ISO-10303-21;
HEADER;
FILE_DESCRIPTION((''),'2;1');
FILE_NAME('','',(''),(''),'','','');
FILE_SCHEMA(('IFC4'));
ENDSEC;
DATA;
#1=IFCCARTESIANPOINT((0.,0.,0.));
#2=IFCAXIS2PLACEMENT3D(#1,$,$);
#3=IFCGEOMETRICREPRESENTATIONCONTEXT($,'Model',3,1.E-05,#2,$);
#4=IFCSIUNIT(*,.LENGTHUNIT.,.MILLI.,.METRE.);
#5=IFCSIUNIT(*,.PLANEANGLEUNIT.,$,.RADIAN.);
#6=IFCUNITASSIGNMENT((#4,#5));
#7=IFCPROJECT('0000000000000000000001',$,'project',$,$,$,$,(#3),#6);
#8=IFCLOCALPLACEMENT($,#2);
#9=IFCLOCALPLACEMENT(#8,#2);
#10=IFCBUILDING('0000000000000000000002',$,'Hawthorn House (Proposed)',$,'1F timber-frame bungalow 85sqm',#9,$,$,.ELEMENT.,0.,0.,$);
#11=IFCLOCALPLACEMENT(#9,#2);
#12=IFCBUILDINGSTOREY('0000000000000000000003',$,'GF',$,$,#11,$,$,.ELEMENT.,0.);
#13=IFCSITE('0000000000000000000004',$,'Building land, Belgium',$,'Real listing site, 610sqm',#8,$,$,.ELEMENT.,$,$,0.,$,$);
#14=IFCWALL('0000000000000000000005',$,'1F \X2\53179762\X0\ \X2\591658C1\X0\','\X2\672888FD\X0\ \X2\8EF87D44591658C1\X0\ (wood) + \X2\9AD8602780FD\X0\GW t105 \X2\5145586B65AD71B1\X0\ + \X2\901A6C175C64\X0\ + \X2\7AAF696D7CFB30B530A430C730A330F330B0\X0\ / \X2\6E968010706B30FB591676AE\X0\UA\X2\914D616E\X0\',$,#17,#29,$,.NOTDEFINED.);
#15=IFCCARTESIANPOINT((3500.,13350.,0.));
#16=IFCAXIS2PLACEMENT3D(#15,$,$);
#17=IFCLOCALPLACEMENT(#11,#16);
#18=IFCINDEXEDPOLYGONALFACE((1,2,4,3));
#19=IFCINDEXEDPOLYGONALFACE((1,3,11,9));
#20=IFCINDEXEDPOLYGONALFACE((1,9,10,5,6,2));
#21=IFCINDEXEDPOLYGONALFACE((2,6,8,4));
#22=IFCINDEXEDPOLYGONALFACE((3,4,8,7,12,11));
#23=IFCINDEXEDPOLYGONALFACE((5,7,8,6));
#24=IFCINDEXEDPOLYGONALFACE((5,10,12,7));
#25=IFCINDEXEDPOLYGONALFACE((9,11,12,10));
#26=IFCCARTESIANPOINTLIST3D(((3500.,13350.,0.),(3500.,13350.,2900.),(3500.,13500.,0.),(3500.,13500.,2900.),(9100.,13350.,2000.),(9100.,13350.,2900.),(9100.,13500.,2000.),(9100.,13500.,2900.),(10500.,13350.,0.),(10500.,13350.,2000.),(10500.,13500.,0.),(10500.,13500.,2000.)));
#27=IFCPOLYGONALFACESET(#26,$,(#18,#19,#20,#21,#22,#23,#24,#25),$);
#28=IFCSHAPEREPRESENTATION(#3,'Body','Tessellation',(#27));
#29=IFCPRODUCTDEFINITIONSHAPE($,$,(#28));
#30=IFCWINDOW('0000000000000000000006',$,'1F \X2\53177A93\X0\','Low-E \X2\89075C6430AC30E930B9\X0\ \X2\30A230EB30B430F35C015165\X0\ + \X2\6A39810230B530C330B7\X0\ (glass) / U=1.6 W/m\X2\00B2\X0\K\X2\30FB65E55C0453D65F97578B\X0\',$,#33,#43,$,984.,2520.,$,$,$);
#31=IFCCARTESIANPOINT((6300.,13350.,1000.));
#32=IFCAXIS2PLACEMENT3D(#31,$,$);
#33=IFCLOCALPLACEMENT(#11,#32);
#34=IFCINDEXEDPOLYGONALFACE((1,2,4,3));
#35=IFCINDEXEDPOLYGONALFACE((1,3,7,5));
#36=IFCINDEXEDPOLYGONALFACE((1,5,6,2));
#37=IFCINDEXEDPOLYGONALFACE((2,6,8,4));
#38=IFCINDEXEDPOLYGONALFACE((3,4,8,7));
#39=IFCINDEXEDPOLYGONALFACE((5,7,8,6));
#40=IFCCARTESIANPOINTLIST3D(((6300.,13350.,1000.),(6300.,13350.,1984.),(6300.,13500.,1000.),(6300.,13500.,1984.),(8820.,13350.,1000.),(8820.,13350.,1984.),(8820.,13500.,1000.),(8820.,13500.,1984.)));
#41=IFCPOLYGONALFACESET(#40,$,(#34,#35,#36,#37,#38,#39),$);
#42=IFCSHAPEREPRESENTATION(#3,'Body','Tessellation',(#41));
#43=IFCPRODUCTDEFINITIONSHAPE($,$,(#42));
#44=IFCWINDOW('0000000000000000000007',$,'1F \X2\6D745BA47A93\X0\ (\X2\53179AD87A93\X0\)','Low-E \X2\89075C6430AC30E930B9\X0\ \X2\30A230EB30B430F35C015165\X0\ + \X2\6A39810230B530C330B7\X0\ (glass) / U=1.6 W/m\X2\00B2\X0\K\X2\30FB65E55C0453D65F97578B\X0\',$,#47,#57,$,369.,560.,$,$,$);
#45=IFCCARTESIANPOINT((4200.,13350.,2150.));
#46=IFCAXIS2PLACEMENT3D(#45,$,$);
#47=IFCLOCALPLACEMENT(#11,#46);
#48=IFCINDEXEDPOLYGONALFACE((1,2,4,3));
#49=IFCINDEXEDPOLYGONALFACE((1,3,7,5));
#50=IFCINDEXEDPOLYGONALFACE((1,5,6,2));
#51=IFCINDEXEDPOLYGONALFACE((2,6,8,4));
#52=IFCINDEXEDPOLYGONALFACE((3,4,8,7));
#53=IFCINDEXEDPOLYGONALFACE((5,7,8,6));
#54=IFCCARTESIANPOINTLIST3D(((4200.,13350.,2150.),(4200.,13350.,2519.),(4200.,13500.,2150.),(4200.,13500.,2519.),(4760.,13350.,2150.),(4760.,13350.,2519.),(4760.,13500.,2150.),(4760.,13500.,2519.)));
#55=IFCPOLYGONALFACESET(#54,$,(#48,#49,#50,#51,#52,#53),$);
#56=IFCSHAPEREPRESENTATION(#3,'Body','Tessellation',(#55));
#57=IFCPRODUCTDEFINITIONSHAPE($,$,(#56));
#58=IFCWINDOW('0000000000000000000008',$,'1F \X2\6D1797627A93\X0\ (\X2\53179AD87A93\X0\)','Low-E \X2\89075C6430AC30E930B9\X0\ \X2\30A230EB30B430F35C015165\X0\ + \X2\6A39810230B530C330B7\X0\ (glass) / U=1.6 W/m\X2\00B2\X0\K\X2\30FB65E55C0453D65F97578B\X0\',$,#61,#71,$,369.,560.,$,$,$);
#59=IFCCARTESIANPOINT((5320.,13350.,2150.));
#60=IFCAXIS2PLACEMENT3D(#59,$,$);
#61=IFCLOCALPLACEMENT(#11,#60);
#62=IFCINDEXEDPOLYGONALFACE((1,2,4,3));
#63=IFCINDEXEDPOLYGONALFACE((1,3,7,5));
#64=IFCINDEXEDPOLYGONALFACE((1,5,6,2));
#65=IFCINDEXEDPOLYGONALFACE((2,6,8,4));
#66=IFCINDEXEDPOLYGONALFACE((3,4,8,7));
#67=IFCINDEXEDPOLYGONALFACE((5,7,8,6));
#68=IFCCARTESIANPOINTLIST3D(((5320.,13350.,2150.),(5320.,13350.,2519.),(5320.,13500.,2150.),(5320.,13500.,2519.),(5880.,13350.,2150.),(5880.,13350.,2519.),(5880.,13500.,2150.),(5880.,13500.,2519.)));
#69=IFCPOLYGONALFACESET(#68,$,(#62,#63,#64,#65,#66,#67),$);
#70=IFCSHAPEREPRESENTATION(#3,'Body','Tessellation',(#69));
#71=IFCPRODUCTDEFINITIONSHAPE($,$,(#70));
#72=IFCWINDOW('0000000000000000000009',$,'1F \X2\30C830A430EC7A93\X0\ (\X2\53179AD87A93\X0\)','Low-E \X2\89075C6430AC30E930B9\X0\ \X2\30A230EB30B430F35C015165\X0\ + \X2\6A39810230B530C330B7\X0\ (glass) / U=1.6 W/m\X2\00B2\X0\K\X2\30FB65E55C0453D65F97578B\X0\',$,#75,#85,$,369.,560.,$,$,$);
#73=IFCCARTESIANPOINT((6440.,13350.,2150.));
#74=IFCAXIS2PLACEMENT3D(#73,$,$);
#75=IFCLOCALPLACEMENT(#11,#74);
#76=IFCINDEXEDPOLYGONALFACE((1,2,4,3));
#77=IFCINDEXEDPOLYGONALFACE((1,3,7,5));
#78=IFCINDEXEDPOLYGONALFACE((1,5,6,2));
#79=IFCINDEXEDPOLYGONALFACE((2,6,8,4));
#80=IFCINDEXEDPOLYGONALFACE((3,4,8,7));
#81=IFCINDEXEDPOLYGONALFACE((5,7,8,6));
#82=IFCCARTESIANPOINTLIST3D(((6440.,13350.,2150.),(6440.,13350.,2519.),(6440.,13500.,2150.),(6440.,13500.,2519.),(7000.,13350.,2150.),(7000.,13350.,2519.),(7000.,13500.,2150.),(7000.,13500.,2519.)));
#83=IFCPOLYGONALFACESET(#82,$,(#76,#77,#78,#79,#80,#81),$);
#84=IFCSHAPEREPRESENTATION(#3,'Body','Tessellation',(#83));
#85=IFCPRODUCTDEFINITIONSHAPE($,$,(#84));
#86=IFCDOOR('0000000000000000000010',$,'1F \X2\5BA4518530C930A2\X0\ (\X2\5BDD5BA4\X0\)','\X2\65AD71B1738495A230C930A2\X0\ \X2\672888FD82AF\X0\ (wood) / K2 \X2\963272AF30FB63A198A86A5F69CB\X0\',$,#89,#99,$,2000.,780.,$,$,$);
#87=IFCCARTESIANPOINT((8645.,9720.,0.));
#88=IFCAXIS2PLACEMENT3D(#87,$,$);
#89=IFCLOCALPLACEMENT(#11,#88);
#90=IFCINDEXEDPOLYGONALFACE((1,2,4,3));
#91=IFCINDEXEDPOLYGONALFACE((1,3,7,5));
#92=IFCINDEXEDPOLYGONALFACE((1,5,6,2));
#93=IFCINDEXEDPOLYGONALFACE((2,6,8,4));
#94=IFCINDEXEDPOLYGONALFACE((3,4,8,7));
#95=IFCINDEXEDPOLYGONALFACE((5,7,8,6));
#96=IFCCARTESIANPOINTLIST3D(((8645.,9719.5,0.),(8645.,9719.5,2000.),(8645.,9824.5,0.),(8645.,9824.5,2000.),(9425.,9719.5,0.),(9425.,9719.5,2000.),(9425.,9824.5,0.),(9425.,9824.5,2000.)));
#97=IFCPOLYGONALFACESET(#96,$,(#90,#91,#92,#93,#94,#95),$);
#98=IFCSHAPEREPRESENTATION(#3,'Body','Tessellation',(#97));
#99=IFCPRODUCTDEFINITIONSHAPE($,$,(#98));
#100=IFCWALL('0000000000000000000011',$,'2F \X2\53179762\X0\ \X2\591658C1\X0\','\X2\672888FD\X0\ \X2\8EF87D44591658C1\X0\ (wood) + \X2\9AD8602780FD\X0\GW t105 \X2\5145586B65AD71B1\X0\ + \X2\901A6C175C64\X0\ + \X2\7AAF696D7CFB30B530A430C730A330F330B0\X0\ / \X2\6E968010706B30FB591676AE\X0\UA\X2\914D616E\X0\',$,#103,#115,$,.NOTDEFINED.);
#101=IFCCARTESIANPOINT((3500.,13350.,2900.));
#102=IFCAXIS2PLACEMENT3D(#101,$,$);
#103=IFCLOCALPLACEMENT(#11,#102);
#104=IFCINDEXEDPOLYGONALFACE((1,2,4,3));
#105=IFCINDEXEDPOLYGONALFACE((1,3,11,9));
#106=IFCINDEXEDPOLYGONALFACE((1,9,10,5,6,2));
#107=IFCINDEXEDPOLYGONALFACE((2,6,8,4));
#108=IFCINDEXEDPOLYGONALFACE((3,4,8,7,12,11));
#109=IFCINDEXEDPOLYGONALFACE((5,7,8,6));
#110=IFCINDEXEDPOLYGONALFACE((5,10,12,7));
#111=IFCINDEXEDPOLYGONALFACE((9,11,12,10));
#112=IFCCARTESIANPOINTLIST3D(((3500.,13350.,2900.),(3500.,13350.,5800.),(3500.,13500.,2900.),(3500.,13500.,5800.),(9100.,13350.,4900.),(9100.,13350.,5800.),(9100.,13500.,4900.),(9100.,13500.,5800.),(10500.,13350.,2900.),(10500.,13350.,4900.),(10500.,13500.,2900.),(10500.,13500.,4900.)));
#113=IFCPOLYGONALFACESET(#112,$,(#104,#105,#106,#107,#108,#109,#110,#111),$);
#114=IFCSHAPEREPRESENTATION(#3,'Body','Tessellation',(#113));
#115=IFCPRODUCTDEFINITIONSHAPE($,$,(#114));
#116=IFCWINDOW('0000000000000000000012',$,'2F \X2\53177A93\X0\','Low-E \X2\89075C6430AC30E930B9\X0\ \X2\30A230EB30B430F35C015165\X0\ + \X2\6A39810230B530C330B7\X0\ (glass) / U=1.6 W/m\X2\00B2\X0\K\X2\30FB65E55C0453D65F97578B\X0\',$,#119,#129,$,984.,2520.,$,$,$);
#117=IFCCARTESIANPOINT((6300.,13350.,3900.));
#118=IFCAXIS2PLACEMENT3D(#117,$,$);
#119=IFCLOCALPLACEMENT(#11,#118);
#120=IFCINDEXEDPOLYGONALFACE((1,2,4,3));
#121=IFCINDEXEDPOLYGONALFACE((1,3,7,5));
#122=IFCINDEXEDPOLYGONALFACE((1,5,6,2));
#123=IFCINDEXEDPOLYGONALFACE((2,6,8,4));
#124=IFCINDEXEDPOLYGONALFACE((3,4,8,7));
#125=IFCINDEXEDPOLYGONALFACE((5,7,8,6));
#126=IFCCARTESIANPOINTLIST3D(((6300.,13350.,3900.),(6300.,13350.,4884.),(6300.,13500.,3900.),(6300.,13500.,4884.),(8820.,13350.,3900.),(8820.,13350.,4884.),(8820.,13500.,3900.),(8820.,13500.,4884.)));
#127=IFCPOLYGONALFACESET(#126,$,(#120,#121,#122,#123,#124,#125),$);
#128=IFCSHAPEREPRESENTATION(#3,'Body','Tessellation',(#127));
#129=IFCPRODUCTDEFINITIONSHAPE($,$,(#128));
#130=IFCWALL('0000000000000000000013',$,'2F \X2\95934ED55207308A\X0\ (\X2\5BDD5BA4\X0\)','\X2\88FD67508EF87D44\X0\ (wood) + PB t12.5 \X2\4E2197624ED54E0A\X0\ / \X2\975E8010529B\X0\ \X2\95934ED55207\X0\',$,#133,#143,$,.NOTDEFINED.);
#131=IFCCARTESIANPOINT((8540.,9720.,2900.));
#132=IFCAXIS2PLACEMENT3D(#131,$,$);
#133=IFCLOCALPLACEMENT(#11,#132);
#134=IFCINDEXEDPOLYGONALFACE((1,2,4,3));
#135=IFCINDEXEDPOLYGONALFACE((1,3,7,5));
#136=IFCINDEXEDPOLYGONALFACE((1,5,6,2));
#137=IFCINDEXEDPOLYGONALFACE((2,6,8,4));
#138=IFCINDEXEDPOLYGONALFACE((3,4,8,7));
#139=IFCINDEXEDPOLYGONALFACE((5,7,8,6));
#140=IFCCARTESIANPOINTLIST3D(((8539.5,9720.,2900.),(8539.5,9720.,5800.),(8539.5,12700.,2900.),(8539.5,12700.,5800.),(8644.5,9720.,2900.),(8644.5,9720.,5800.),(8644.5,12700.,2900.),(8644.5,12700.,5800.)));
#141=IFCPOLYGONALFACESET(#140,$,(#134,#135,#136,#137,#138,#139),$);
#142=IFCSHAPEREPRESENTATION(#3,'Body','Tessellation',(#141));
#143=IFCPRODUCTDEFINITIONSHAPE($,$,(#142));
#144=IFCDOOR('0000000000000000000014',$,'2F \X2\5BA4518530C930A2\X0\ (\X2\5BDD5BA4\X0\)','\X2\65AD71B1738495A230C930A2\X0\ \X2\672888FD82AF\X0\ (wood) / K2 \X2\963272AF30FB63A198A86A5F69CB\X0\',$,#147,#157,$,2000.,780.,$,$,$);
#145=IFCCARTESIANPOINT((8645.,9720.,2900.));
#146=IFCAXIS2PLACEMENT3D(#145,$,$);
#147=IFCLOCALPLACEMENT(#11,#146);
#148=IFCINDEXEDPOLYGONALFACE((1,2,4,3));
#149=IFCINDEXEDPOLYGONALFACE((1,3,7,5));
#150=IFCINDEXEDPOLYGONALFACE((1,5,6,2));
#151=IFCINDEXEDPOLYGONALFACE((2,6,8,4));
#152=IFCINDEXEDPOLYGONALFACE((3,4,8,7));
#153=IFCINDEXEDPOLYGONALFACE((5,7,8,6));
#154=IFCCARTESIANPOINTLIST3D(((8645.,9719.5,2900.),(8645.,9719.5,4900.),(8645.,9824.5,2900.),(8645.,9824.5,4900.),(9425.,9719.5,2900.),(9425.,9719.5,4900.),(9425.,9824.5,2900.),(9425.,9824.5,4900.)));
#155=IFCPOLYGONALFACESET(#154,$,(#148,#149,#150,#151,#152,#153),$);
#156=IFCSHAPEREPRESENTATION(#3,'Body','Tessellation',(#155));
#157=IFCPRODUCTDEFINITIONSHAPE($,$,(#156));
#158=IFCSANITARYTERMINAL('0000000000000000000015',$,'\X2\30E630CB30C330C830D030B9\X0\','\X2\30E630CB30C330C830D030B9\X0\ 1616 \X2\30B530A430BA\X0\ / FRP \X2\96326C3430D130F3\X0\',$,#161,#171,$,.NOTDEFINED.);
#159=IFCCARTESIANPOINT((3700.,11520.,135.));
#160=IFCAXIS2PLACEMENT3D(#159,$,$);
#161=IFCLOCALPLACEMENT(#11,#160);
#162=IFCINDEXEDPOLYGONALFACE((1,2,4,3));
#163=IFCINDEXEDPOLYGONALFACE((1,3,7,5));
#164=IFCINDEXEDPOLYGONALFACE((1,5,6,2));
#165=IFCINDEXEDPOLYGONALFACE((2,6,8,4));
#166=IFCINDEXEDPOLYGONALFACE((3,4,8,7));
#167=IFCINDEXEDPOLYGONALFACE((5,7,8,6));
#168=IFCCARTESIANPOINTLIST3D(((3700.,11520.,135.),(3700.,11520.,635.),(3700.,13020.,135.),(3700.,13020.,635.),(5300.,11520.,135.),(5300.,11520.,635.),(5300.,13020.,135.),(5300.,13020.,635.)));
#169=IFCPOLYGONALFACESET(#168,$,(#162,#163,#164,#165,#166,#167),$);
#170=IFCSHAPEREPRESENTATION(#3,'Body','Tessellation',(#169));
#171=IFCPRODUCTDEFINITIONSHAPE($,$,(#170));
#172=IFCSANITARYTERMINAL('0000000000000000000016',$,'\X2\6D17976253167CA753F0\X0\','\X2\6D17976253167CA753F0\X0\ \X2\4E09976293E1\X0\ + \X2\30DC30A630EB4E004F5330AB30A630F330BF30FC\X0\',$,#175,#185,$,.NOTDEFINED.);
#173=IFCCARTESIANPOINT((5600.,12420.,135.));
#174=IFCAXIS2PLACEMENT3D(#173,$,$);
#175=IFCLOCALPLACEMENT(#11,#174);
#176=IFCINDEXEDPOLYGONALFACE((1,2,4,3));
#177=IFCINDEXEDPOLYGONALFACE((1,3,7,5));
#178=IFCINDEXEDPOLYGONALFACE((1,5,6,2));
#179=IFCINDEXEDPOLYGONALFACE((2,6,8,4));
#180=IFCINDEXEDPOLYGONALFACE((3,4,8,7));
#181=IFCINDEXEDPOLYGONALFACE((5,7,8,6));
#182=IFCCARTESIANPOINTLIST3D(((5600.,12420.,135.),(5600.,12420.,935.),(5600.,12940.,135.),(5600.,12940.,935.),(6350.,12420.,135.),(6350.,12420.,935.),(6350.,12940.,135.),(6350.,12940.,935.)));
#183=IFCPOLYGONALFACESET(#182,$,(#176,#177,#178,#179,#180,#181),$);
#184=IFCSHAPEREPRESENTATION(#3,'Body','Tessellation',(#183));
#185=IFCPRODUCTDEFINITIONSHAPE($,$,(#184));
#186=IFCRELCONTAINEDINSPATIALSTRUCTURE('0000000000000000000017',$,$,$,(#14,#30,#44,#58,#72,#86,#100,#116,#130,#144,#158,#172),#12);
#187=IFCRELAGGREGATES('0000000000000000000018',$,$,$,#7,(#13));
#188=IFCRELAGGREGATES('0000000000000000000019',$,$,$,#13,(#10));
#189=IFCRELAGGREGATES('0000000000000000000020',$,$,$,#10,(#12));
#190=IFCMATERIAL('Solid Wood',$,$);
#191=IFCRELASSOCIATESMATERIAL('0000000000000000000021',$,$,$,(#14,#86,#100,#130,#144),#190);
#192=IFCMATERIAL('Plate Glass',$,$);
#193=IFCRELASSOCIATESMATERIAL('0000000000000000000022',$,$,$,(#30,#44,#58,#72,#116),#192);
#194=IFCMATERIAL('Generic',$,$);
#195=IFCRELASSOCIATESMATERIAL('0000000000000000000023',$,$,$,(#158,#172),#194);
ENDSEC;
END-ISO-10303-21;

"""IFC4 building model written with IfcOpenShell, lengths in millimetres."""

from ifc_helpers import new_model, si_unit, frame, frame_2d, origin, place, context, project, spatial, rectangle, extrude, material, element, fill, save


model = new_model("IFC4")

# Units and contexts
model_context = context("Model", 3, precision=1e-05, world=origin())
ifc_project = project(units=[si_unit("LENGTHUNIT", "METRE", prefix="MILLI"), si_unit("PLANEANGLEUNIT", "RADIAN")], contexts=[model_context])

# Site, building, storey
site_placement = place(None, origin())
site = spatial("IfcSite", under=ifc_project, at=site_placement, Name="Building land, Belgium", ObjectType="Real listing site, 610sqm", CompositionType="ELEMENT", RefElevation=0.0)
building_placement = place(site_placement, origin())
building = spatial("IfcBuilding", under=site, at=building_placement, Name="Hawthorn House (Proposed)", ObjectType="1F timber-frame bungalow 85sqm", CompositionType="ELEMENT", ElevationOfRefHeight=0.0, ElevationOfTerrain=0.0)
storey_placement = place(building_placement, origin())
storey = spatial("IfcBuildingStorey", under=building, at=storey_placement, Name="GF", CompositionType="ELEMENT", Elevation=0.0)

# Wall, openings, windows
ifc_material_1 = material(Name="Solid Wood")
wall_1_placement = place(storey_placement, frame((3500.0, 13350.0, 0.0)))
wall_1 = element("IfcWall", 1, at=wall_1_placement, inside=storey, material=ifc_material_1, Name="1F 北面 外壁", Description="木製 軸組外壁 (wood) + 高性能GW t105 充填断熱 + 通気層 + 窯業系サイディング / 準耐火・外皮UA配慮", PredefinedType="NOTDEFINED", context=model_context, shape_type="SweptSolid", body=[
    extrude(rectangle(XDim=7000.0, YDim=150.0, at=frame_2d((3500.0, 75.0))), frame((3500.0, 13350.0, 0.0)), (0.0, 0.0, 1.0), 2900.0),
])
opening_1_placement = place(storey_placement, frame((6300.0, 13350.0, 1000.0)))
opening_1 = element("IfcOpeningElement", 2, at=opening_1_placement, cuts=wall_1, PredefinedType="NOTDEFINED", context=model_context, shape_type="SweptSolid", body=[
    extrude(rectangle(XDim=2520.0, YDim=150.0, at=frame_2d((1260.0, 75.0))), frame((6300.0, 13350.0, 1000.0)), (0.0, 0.0, 1.0), 984.0),
])
opening_2_placement = place(storey_placement, frame((4200.0, 13350.0, 2150.0)))
opening_2 = element("IfcOpeningElement", 3, at=opening_2_placement, cuts=wall_1, PredefinedType="NOTDEFINED", context=model_context, shape_type="SweptSolid", body=[
    extrude(rectangle(XDim=560.0, YDim=150.0, at=frame_2d((280.0, 75.0))), frame((4200.0, 13350.0, 2150.0)), (0.0, 0.0, 1.0), 369.0),
])
opening_3_placement = place(storey_placement, frame((5320.0, 13350.0, 2150.0)))
opening_3 = element("IfcOpeningElement", 4, at=opening_3_placement, cuts=wall_1, PredefinedType="NOTDEFINED", context=model_context, shape_type="SweptSolid", body=[
    extrude(rectangle(XDim=560.0, YDim=150.0, at=frame_2d((280.0, 75.0))), frame((5320.0, 13350.0, 2150.0)), (0.0, 0.0, 1.0), 369.0),
])
opening_4_placement = place(storey_placement, frame((6440.0, 13350.0, 2150.0)))
opening_4 = element("IfcOpeningElement", 5, at=opening_4_placement, cuts=wall_1, PredefinedType="NOTDEFINED", context=model_context, shape_type="SweptSolid", body=[
    extrude(rectangle(XDim=560.0, YDim=150.0, at=frame_2d((280.0, 75.0))), frame((6440.0, 13350.0, 2150.0)), (0.0, 0.0, 1.0), 369.0),
])
ifc_material_2 = material(Name="Plate Glass")
window_1_placement = place(storey_placement, frame((6300.0, 13350.0, 1000.0)))
window_1 = element("IfcWindow", 6, at=window_1_placement, inside=storey, material=ifc_material_2, Name="1F 北窓", Description="Low-E 複層ガラス アルゴン封入 + 樹脂サッシ (glass) / U=1.6 W/m²K・日射取得型", OverallHeight=984.0, OverallWidth=2520.0, context=model_context, shape_type="SweptSolid", body=[
    extrude(rectangle(XDim=2520.0, YDim=150.0, at=frame_2d((1260.0, 75.0))), frame((6300.0, 13350.0, 1000.0)), (0.0, 0.0, 1.0), 984.0),
])
fill(opening_1, window_1)
window_2_placement = place(storey_placement, frame((4200.0, 13350.0, 2150.0)))
window_2 = element("IfcWindow", 7, at=window_2_placement, inside=storey, material=ifc_material_2, Name="1F 浴室窓 (北高窓)", Description="Low-E 複層ガラス アルゴン封入 + 樹脂サッシ (glass) / U=1.6 W/m²K・日射取得型", OverallHeight=369.0, OverallWidth=560.0, context=model_context, shape_type="SweptSolid", body=[
    extrude(rectangle(XDim=560.0, YDim=150.0, at=frame_2d((280.0, 75.0))), frame((4200.0, 13350.0, 2150.0)), (0.0, 0.0, 1.0), 369.0),
])
fill(opening_2, window_2)
window_3_placement = place(storey_placement, frame((5320.0, 13350.0, 2150.0)))
window_3 = element("IfcWindow", 8, at=window_3_placement, inside=storey, material=ifc_material_2, Name="1F 洗面窓 (北高窓)", Description="Low-E 複層ガラス アルゴン封入 + 樹脂サッシ (glass) / U=1.6 W/m²K・日射取得型", OverallHeight=369.0, OverallWidth=560.0, context=model_context, shape_type="SweptSolid", body=[
    extrude(rectangle(XDim=560.0, YDim=150.0, at=frame_2d((280.0, 75.0))), frame((5320.0, 13350.0, 2150.0)), (0.0, 0.0, 1.0), 369.0),
])
fill(opening_3, window_3)
window_4_placement = place(storey_placement, frame((6440.0, 13350.0, 2150.0)))
window_4 = element("IfcWindow", 9, at=window_4_placement, inside=storey, material=ifc_material_2, Name="1F トイレ窓 (北高窓)", Description="Low-E 複層ガラス アルゴン封入 + 樹脂サッシ (glass) / U=1.6 W/m²K・日射取得型", OverallHeight=369.0, OverallWidth=560.0, context=model_context, shape_type="SweptSolid", body=[
    extrude(rectangle(XDim=560.0, YDim=150.0, at=frame_2d((280.0, 75.0))), frame((6440.0, 13350.0, 2150.0)), (0.0, 0.0, 1.0), 369.0),
])
fill(opening_4, window_4)

# Door
door_1_placement = place(storey_placement, frame((8645.0, 9720.0, 0.0)))
element("IfcDoor", 10, at=door_1_placement, inside=storey, material=ifc_material_1, Name="1F 室内ドア (寝室)", Description="断熱玄関ドア 木製芯 (wood) / K2 防犯・採風機構", OverallHeight=2000.0, OverallWidth=780.0, context=model_context, shape_type="SweptSolid", body=[
    extrude(rectangle(XDim=780.0, YDim=105.0, at=frame_2d((390.0, 52.0))), frame((8645.0, 9720.0, 0.0)), (0.0, 0.0, 1.0), 2000.0),
])

# Wall, opening, window
wall_2_placement = place(storey_placement, frame((3500.0, 13350.0, 2900.0)))
wall_2 = element("IfcWall", 11, at=wall_2_placement, inside=storey, material=ifc_material_1, Name="2F 北面 外壁", Description="木製 軸組外壁 (wood) + 高性能GW t105 充填断熱 + 通気層 + 窯業系サイディング / 準耐火・外皮UA配慮", PredefinedType="NOTDEFINED", context=model_context, shape_type="SweptSolid", body=[
    extrude(rectangle(XDim=7000.0, YDim=150.0, at=frame_2d((3500.0, 75.0))), frame((3500.0, 13350.0, 2900.0)), (0.0, 0.0, 1.0), 2900.0),
])
opening_5_placement = place(storey_placement, frame((6300.0, 13350.0, 3900.0)))
opening_5 = element("IfcOpeningElement", 12, at=opening_5_placement, cuts=wall_2, PredefinedType="NOTDEFINED", context=model_context, shape_type="SweptSolid", body=[
    extrude(rectangle(XDim=2520.0, YDim=150.0, at=frame_2d((1260.0, 75.0))), frame((6300.0, 13350.0, 3900.0)), (0.0, 0.0, 1.0), 984.0),
])
window_5_placement = place(storey_placement, frame((6300.0, 13350.0, 3900.0)))
window_5 = element("IfcWindow", 13, at=window_5_placement, inside=storey, material=ifc_material_2, Name="2F 北窓", Description="Low-E 複層ガラス アルゴン封入 + 樹脂サッシ (glass) / U=1.6 W/m²K・日射取得型", OverallHeight=984.0, OverallWidth=2520.0, context=model_context, shape_type="SweptSolid", body=[
    extrude(rectangle(XDim=2520.0, YDim=150.0, at=frame_2d((1260.0, 75.0))), frame((6300.0, 13350.0, 3900.0)), (0.0, 0.0, 1.0), 984.0),
])
fill(opening_5, window_5)

# Wall
wall_3_placement = place(storey_placement, frame((8540.0, 9720.0, 2900.0)))
element("IfcWall", 14, at=wall_3_placement, inside=storey, material=ifc_material_1, Name="2F 間仕切り (寝室)", Description="製材軸組 (wood) + PB t12.5 両面仕上 / 非耐力 間仕切", PredefinedType="NOTDEFINED", context=model_context, shape_type="SweptSolid", body=[
    extrude(rectangle(XDim=105.0, YDim=2980.0, at=frame_2d((52.0, 1490.0))), frame((8540.0, 9720.0, 2900.0)), (0.0, 0.0, 1.0), 2900.0),
])

# Door
door_2_placement = place(storey_placement, frame((8645.0, 9720.0, 2900.0)))
element("IfcDoor", 15, at=door_2_placement, inside=storey, material=ifc_material_1, Name="2F 室内ドア (寝室)", Description="断熱玄関ドア 木製芯 (wood) / K2 防犯・採風機構", OverallHeight=2000.0, OverallWidth=780.0, context=model_context, shape_type="SweptSolid", body=[
    extrude(rectangle(XDim=780.0, YDim=105.0, at=frame_2d((390.0, 52.0))), frame((8645.0, 9720.0, 2900.0)), (0.0, 0.0, 1.0), 2000.0),
])

# Sanitary terminals
ifc_material_3 = material(Name="Generic")
sanitary_terminal_1_placement = place(storey_placement, frame((3700.0, 11520.0, 135.0)))
element("IfcSanitaryTerminal", 16, at=sanitary_terminal_1_placement, inside=storey, material=ifc_material_3, Name="ユニットバス", Description="ユニットバス 1616 サイズ / FRP 防水パン", PredefinedType="NOTDEFINED", context=model_context, shape_type="SweptSolid", body=[
    extrude(rectangle(XDim=1600.0, YDim=1500.0, at=frame_2d((800.0, 750.0))), frame((3700.0, 11520.0, 135.0)), (0.0, 0.0, 1.0), 500.0),
])
sanitary_terminal_2_placement = place(storey_placement, frame((5600.0, 12420.0, 135.0)))
element("IfcSanitaryTerminal", 17, at=sanitary_terminal_2_placement, inside=storey, material=ifc_material_3, Name="洗面化粧台", Description="洗面化粧台 三面鏡 + ボウル一体カウンター", PredefinedType="NOTDEFINED", context=model_context, shape_type="SweptSolid", body=[
    extrude(rectangle(XDim=750.0, YDim=520.0, at=frame_2d((375.0, 260.0))), frame((5600.0, 12420.0, 135.0)), (0.0, 0.0, 1.0), 800.0),
])

save(model, "model.ifc")
